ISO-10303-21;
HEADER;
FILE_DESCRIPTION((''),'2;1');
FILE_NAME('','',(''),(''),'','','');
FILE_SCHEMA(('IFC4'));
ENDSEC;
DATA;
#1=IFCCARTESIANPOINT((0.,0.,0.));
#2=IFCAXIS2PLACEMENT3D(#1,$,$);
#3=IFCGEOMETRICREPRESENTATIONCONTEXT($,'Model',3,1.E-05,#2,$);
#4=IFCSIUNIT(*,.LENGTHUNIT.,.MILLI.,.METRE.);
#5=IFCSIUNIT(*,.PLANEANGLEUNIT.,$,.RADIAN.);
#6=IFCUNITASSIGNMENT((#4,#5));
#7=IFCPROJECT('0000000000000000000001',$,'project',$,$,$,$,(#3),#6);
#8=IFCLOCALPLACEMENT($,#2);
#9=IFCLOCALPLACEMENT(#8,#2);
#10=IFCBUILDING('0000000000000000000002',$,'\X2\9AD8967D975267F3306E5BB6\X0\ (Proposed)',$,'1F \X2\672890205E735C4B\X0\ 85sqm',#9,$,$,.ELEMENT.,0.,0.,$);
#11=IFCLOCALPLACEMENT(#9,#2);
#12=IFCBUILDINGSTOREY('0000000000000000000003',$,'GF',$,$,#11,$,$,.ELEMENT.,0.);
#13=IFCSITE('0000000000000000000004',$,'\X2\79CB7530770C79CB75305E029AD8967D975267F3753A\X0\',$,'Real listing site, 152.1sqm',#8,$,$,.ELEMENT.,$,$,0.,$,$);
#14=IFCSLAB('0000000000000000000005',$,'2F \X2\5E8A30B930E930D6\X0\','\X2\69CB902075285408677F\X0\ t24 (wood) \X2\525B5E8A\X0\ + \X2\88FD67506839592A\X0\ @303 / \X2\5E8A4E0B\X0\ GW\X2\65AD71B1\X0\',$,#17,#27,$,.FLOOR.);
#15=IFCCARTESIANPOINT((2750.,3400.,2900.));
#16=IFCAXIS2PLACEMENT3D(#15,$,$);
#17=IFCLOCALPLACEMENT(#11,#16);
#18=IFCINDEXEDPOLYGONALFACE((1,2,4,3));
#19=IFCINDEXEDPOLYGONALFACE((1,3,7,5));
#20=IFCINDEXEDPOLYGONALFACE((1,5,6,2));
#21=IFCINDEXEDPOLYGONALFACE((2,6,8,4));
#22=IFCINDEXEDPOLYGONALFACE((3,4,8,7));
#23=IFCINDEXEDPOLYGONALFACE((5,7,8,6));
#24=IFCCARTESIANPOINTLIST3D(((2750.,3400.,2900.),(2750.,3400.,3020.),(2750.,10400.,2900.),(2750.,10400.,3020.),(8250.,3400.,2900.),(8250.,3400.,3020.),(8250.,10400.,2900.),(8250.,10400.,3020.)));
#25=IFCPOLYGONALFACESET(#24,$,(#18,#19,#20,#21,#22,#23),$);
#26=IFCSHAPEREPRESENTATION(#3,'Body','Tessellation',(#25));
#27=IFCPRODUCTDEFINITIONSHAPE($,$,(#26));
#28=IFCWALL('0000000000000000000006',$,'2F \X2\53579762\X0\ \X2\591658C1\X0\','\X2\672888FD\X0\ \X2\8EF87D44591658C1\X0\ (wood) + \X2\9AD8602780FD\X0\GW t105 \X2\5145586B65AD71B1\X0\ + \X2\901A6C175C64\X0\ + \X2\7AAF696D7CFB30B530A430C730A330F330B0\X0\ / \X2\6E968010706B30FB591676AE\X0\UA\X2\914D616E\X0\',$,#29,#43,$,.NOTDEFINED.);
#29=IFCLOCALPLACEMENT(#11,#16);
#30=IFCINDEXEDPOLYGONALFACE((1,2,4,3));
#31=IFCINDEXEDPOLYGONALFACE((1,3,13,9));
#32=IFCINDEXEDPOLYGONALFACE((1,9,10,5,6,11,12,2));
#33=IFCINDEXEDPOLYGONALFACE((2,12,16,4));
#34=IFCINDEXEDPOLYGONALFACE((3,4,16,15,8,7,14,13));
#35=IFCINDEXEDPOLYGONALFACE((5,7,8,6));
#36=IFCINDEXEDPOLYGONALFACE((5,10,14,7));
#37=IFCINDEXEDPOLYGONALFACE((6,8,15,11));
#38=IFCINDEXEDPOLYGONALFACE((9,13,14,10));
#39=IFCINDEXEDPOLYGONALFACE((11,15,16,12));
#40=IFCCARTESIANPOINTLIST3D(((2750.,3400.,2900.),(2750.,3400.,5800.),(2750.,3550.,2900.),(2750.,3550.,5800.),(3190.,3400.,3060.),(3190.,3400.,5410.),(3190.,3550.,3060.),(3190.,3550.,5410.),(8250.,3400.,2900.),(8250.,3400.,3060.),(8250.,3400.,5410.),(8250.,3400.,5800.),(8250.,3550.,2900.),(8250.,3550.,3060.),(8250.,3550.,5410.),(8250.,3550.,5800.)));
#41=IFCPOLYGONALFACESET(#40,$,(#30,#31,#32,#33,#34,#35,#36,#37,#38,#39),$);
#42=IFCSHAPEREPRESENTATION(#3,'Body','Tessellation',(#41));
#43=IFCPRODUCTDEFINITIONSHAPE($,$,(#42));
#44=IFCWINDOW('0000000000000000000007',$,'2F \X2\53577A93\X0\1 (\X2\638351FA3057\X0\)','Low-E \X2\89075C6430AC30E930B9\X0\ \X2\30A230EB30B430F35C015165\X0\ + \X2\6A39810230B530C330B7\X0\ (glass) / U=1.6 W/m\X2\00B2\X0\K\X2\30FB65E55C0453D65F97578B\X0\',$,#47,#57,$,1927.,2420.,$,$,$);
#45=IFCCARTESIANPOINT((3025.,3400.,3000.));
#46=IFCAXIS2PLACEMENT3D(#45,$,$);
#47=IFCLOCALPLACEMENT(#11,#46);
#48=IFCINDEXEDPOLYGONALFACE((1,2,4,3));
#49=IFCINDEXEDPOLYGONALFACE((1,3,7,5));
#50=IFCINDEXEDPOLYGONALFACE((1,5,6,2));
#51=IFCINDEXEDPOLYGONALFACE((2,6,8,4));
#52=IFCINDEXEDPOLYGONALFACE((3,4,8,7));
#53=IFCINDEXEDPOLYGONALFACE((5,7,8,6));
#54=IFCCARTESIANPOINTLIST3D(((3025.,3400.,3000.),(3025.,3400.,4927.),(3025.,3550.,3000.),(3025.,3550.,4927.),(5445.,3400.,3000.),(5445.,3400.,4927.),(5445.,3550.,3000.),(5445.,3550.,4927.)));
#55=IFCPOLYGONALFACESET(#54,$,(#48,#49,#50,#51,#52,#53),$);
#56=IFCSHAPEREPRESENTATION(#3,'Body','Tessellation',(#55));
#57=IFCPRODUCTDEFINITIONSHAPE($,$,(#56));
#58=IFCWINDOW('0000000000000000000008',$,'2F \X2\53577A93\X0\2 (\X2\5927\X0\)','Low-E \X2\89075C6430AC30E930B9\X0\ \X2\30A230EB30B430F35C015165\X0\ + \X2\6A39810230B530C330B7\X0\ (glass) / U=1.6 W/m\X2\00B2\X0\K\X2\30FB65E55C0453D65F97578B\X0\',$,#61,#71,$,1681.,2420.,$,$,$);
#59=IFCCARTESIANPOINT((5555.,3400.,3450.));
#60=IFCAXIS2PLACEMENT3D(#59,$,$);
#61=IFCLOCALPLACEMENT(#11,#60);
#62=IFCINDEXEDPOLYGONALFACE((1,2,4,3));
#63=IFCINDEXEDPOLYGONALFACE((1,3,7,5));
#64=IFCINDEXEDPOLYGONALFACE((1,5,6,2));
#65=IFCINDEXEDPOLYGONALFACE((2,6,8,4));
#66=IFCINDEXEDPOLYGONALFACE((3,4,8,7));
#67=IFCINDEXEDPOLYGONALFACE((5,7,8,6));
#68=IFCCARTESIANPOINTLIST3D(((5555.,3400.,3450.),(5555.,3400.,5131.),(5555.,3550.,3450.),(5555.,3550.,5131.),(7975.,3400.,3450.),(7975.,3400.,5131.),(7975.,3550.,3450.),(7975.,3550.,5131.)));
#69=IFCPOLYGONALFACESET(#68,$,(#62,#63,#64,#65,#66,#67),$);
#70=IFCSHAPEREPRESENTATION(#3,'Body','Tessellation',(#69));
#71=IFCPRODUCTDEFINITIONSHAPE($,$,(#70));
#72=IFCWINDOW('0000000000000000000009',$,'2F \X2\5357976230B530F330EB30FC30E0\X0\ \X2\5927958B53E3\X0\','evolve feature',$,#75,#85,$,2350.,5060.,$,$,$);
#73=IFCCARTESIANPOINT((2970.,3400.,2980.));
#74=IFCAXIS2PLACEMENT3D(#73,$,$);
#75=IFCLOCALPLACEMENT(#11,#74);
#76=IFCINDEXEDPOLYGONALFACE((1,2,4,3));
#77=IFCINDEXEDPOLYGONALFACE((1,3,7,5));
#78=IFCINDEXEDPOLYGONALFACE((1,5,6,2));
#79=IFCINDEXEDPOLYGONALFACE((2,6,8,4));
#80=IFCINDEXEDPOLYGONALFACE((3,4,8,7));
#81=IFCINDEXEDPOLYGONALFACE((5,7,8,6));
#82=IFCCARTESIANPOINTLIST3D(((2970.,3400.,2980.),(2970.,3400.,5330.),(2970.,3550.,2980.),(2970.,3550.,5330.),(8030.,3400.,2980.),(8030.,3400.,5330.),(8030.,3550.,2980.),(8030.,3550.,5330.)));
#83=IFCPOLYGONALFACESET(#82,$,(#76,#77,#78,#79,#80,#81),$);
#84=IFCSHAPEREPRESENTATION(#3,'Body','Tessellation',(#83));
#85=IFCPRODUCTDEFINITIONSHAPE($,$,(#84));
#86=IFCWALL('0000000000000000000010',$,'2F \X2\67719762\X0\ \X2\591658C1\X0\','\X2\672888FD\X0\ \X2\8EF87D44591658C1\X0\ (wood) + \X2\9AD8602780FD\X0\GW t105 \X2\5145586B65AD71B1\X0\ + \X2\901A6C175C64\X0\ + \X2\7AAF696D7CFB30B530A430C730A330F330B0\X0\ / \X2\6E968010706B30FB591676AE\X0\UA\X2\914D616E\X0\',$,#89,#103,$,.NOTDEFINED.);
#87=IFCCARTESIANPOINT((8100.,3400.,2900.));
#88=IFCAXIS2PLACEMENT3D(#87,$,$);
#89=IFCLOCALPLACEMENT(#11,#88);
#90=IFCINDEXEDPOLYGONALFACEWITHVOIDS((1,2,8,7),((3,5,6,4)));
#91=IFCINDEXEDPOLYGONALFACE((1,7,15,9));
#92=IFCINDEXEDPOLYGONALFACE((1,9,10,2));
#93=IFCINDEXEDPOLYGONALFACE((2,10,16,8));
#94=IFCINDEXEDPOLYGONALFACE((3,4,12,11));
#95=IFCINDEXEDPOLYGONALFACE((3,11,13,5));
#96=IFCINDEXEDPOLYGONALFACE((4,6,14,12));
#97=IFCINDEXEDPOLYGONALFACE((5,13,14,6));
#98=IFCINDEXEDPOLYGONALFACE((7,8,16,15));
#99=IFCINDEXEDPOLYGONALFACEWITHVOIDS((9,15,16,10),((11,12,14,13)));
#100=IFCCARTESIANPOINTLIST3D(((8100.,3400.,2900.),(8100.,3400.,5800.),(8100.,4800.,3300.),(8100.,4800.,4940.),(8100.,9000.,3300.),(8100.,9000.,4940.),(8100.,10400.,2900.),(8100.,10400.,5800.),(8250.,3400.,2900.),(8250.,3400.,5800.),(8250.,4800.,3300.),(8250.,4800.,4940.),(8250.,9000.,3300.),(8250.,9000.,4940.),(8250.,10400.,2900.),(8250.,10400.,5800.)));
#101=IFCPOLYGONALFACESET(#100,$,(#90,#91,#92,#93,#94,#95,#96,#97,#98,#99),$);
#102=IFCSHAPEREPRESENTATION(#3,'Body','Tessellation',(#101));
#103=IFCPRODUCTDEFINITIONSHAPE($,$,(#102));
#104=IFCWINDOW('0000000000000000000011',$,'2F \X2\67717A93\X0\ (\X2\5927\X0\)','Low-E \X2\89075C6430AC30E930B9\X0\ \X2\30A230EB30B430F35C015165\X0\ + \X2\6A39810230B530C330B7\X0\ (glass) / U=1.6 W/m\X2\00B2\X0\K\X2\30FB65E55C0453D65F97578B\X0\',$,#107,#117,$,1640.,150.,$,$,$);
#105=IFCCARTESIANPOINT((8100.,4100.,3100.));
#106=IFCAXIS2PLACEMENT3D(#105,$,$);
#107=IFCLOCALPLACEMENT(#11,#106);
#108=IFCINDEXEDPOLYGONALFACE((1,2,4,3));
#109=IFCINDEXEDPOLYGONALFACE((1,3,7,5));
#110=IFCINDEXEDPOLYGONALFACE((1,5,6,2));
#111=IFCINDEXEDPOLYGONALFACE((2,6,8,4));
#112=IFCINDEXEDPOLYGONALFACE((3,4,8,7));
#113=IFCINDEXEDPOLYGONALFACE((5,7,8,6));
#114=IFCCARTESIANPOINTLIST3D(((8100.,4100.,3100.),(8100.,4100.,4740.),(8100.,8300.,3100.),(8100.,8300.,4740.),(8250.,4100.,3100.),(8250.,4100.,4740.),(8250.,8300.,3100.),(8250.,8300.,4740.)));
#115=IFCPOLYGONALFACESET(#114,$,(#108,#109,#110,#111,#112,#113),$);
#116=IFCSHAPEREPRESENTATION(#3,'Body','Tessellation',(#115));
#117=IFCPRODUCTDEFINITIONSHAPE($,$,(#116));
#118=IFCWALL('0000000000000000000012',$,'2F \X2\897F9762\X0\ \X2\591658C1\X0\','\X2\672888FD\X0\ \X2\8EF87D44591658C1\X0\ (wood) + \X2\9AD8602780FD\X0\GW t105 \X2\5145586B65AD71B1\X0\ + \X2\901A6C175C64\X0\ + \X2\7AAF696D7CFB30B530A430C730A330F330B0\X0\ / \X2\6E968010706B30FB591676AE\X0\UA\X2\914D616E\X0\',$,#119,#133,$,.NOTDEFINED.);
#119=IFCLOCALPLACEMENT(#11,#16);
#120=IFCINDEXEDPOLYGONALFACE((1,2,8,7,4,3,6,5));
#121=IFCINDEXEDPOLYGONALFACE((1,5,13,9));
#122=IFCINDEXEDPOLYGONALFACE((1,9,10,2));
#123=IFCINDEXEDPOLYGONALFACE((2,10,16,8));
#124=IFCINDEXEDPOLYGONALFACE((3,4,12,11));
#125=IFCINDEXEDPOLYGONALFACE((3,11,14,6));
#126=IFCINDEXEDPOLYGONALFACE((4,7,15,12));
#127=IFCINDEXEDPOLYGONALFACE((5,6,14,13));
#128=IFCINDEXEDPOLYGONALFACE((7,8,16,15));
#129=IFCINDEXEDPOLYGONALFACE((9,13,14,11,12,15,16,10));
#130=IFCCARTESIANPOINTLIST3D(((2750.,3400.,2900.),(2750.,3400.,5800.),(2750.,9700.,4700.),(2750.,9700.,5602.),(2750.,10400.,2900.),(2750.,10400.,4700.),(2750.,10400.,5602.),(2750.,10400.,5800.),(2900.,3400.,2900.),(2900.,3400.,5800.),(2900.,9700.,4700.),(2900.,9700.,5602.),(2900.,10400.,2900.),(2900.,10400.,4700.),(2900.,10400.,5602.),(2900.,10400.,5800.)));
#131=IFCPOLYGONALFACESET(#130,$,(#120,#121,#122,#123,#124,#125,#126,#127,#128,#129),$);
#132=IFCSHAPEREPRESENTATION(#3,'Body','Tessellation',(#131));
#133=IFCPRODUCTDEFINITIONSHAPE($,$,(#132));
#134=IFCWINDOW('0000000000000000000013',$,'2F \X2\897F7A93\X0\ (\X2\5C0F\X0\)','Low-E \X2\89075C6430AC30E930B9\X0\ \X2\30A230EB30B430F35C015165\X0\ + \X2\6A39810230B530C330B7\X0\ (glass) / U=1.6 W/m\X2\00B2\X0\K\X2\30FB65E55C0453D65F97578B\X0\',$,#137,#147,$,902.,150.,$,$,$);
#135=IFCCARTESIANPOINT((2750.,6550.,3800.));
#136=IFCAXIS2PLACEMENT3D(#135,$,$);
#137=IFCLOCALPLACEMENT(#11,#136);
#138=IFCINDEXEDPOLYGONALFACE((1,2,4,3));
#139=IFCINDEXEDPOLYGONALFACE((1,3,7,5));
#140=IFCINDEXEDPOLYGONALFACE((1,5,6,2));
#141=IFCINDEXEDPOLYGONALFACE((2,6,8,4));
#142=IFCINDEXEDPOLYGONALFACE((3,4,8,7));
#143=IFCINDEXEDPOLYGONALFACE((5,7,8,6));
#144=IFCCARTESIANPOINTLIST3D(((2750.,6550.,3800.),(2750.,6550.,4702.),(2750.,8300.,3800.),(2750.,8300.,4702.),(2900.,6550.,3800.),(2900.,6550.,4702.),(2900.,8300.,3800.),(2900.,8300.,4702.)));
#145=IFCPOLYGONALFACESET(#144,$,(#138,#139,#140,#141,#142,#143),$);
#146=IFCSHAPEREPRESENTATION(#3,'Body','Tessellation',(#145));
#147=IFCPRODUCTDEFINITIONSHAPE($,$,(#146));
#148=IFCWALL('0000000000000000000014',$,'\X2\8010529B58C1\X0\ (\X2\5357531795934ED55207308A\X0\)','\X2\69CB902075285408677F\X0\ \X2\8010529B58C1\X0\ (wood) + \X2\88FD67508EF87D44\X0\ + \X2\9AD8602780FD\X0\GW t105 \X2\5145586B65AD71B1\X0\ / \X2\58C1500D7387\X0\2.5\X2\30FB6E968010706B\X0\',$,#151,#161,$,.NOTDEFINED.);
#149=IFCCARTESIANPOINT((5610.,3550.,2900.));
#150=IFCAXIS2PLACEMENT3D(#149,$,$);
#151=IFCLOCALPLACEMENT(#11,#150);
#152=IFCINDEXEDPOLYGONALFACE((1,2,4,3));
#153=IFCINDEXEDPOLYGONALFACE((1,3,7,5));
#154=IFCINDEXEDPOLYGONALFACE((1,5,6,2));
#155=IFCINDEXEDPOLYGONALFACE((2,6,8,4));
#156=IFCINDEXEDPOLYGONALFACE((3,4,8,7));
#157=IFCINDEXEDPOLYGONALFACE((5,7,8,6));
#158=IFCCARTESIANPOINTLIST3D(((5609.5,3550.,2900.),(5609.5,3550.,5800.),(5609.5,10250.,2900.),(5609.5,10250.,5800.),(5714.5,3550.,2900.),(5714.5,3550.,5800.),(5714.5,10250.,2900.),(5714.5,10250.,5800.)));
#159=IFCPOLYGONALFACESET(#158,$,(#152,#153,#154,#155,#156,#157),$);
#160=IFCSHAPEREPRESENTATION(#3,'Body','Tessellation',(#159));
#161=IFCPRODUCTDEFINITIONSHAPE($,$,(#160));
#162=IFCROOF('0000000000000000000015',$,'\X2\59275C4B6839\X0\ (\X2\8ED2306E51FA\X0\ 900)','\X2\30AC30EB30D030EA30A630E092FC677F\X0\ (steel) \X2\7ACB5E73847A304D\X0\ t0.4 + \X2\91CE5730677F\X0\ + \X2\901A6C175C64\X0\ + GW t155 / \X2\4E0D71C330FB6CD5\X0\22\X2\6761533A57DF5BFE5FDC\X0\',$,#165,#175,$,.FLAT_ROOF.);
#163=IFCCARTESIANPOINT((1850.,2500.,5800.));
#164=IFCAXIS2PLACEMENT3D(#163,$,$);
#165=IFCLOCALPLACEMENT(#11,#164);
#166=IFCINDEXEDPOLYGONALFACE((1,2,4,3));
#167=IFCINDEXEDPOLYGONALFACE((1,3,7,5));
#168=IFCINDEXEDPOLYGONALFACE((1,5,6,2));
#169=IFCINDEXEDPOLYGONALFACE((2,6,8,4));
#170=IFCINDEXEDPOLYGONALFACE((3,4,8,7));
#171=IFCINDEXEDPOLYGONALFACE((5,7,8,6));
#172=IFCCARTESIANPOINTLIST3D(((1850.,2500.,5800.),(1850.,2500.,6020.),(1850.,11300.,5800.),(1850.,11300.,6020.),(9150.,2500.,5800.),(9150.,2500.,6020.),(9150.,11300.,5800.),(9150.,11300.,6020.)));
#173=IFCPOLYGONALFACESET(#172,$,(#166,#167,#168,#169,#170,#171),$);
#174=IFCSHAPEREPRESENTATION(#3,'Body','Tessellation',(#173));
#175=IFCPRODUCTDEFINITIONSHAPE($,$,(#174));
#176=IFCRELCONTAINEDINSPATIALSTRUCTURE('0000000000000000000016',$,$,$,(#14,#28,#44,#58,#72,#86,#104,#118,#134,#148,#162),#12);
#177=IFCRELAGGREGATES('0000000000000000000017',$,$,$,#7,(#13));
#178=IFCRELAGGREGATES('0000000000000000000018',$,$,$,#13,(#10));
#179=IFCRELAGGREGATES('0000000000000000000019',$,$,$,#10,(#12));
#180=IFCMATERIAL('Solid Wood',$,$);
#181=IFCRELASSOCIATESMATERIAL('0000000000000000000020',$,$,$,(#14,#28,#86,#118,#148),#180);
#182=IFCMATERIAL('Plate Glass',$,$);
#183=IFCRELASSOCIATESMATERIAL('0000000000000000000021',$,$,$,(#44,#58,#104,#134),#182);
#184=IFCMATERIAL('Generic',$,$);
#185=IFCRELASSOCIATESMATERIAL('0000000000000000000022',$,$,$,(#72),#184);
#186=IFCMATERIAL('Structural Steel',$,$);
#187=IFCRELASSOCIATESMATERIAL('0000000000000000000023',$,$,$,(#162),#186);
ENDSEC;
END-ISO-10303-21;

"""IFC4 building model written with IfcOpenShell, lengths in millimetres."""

from ifc_helpers import new_model, si_unit, frame, frame_2d, origin, place, context, project, spatial, rectangle, extrude, material, element, fill, save


model = new_model("IFC4")

# Units and contexts
model_context = context("Model", 3, precision=1e-05, world=origin())
ifc_project = project(units=[si_unit("LENGTHUNIT", "METRE", prefix="MILLI"), si_unit("PLANEANGLEUNIT", "RADIAN")], contexts=[model_context])

# Site, building, storey
site_placement = place(None, origin())
site = spatial("IfcSite", under=ifc_project, at=site_placement, Name="秋田県秋田市高陽青柳町", ObjectType="Real listing site, 152.1sqm", CompositionType="ELEMENT", RefElevation=0.0)
building_placement = place(site_placement, origin())
building = spatial("IfcBuilding", under=site, at=building_placement, Name="高陽青柳の家 (Proposed)", ObjectType="1F 木造平屋 85sqm", CompositionType="ELEMENT", ElevationOfRefHeight=0.0, ElevationOfTerrain=0.0)
storey_placement = place(building_placement, origin())
storey = spatial("IfcBuildingStorey", under=building, at=storey_placement, Name="GF", CompositionType="ELEMENT", Elevation=0.0)

# Slab
ifc_material_1 = material(Name="Solid Wood")
slab_placement = place(storey_placement, frame((2750.0, 3400.0, 2900.0)))
element("IfcSlab", 1, at=slab_placement, inside=storey, material=ifc_material_1, Name="2F 床スラブ", Description="構造用合板 t24 (wood) 剛床 + 製材根太 @303 / 床下 GW断熱", PredefinedType="FLOOR", context=model_context, shape_type="SweptSolid", body=[
    extrude(rectangle(XDim=5500.0, YDim=7000.0, at=frame_2d((2750.0, 3500.0))), frame((2750.0, 3400.0, 2900.0)), (0.0, 0.0, 1.0), 120.0),
])

# Wall, openings, windows
wall_1_placement = place(storey_placement, frame((2750.0, 3400.0, 2900.0)))
wall_1 = element("IfcWall", 2, at=wall_1_placement, inside=storey, material=ifc_material_1, Name="2F 南面 外壁", Description="木製 軸組外壁 (wood) + 高性能GW t105 充填断熱 + 通気層 + 窯業系サイディング / 準耐火・外皮UA配慮", PredefinedType="NOTDEFINED", context=model_context, shape_type="SweptSolid", body=[
    extrude(rectangle(XDim=5500.0, YDim=150.0, at=frame_2d((2750.0, 75.0))), frame((2750.0, 3400.0, 2900.0)), (0.0, 0.0, 1.0), 2900.0),
])
opening_1_placement = place(storey_placement, frame((3025.0, 3400.0, 3000.0)))
opening_1 = element("IfcOpeningElement", 3, at=opening_1_placement, cuts=wall_1, PredefinedType="NOTDEFINED", context=model_context, shape_type="SweptSolid", body=[
    extrude(rectangle(XDim=2420.0, YDim=150.0, at=frame_2d((1210.0, 75.0))), frame((3025.0, 3400.0, 3000.0)), (0.0, 0.0, 1.0), 1927.0),
])
opening_2_placement = place(storey_placement, frame((5555.0, 3400.0, 3450.0)))
opening_2 = element("IfcOpeningElement", 4, at=opening_2_placement, cuts=wall_1, PredefinedType="NOTDEFINED", context=model_context, shape_type="SweptSolid", body=[
    extrude(rectangle(XDim=2420.0, YDim=150.0, at=frame_2d((1210.0, 75.0))), frame((5555.0, 3400.0, 3450.0)), (0.0, 0.0, 1.0), 1681.0),
])
opening_3_placement = place(storey_placement, frame((2970.0, 3400.0, 2980.0)))
opening_3 = element("IfcOpeningElement", 5, at=opening_3_placement, cuts=wall_1, PredefinedType="NOTDEFINED", context=model_context, shape_type="SweptSolid", body=[
    extrude(rectangle(XDim=5060.0, YDim=150.0, at=frame_2d((2530.0, 75.0))), frame((2970.0, 3400.0, 2980.0)), (0.0, 0.0, 1.0), 2350.0),
])
ifc_material_2 = material(Name="Plate Glass")
window_1_placement = place(storey_placement, frame((3025.0, 3400.0, 3000.0)))
window_1 = element("IfcWindow", 6, at=window_1_placement, inside=storey, material=ifc_material_2, Name="2F 南窓1 (掃出し)", Description="Low-E 複層ガラス アルゴン封入 + 樹脂サッシ (glass) / U=1.6 W/m²K・日射取得型", OverallHeight=1927.0, OverallWidth=2420.0, context=model_context, shape_type="SweptSolid", body=[
    extrude(rectangle(XDim=2420.0, YDim=150.0, at=frame_2d((1210.0, 75.0))), frame((3025.0, 3400.0, 3000.0)), (0.0, 0.0, 1.0), 1927.0),
])
fill(opening_1, window_1)
window_2_placement = place(storey_placement, frame((5555.0, 3400.0, 3450.0)))
window_2 = element("IfcWindow", 7, at=window_2_placement, inside=storey, material=ifc_material_2, Name="2F 南窓2 (大)", Description="Low-E 複層ガラス アルゴン封入 + 樹脂サッシ (glass) / U=1.6 W/m²K・日射取得型", OverallHeight=1681.0, OverallWidth=2420.0, context=model_context, shape_type="SweptSolid", body=[
    extrude(rectangle(XDim=2420.0, YDim=150.0, at=frame_2d((1210.0, 75.0))), frame((5555.0, 3400.0, 3450.0)), (0.0, 0.0, 1.0), 1681.0),
])
fill(opening_2, window_2)
ifc_material_3 = material(Name="Generic")
window_3_placement = place(storey_placement, frame((2970.0, 3400.0, 2980.0)))
window_3 = element("IfcWindow", 8, at=window_3_placement, inside=storey, material=ifc_material_3, Name="2F 南面サンルーム 大開口", Description="evolve feature", OverallHeight=2350.0, OverallWidth=5060.0, context=model_context, shape_type="SweptSolid", body=[
    extrude(rectangle(XDim=5060.0, YDim=150.0, at=frame_2d((2530.0, 75.0))), frame((2970.0, 3400.0, 2980.0)), (0.0, 0.0, 1.0), 2350.0),
])
fill(opening_3, window_3)

# Walls, openings, windows
wall_2_placement = place(storey_placement, frame((8100.0, 3400.0, 2900.0)))
wall_2 = element("IfcWall", 9, at=wall_2_placement, inside=storey, material=ifc_material_1, Name="2F 東面 外壁", Description="木製 軸組外壁 (wood) + 高性能GW t105 充填断熱 + 通気層 + 窯業系サイディング / 準耐火・外皮UA配慮", PredefinedType="NOTDEFINED", context=model_context, shape_type="SweptSolid", body=[
    extrude(rectangle(XDim=150.0, YDim=7000.0, at=frame_2d((75.0, 3500.0))), frame((8100.0, 3400.0, 2900.0)), (0.0, 0.0, 1.0), 2900.0),
])
opening_4_placement = place(storey_placement, frame((8100.0, 4100.0, 3100.0)))
opening_4 = element("IfcOpeningElement", 10, at=opening_4_placement, cuts=wall_2, PredefinedType="NOTDEFINED", context=model_context, shape_type="SweptSolid", body=[
    extrude(rectangle(XDim=150.0, YDim=4200.0, at=frame_2d((75.0, 2100.0))), frame((8100.0, 4100.0, 3100.0)), (0.0, 0.0, 1.0), 1640.0),
])
window_4_placement = place(storey_placement, frame((8100.0, 4100.0, 3100.0)))
window_4 = element("IfcWindow", 11, at=window_4_placement, inside=storey, material=ifc_material_2, Name="2F 東窓 (大)", Description="Low-E 複層ガラス アルゴン封入 + 樹脂サッシ (glass) / U=1.6 W/m²K・日射取得型", OverallHeight=1640.0, OverallWidth=150.0, context=model_context, shape_type="SweptSolid", body=[
    extrude(rectangle(XDim=150.0, YDim=4200.0, at=frame_2d((75.0, 2100.0))), frame((8100.0, 4100.0, 3100.0)), (0.0, 0.0, 1.0), 1640.0),
])
fill(opening_4, window_4)
wall_3_placement = place(storey_placement, frame((2750.0, 3400.0, 2900.0)))
wall_3 = element("IfcWall", 12, at=wall_3_placement, inside=storey, material=ifc_material_1, Name="2F 西面 外壁", Description="木製 軸組外壁 (wood) + 高性能GW t105 充填断熱 + 通気層 + 窯業系サイディング / 準耐火・外皮UA配慮", PredefinedType="NOTDEFINED", context=model_context, shape_type="SweptSolid", body=[
    extrude(rectangle(XDim=150.0, YDim=7000.0, at=frame_2d((75.0, 3500.0))), frame((2750.0, 3400.0, 2900.0)), (0.0, 0.0, 1.0), 2900.0),
])
opening_5_placement = place(storey_placement, frame((2750.0, 6550.0, 3800.0)))
opening_5 = element("IfcOpeningElement", 13, at=opening_5_placement, cuts=wall_3, PredefinedType="NOTDEFINED", context=model_context, shape_type="SweptSolid", body=[
    extrude(rectangle(XDim=150.0, YDim=1750.0, at=frame_2d((75.0, 875.0))), frame((2750.0, 6550.0, 3800.0)), (0.0, 0.0, 1.0), 902.0),
])
window_5_placement = place(storey_placement, frame((2750.0, 6550.0, 3800.0)))
window_5 = element("IfcWindow", 14, at=window_5_placement, inside=storey, material=ifc_material_2, Name="2F 西窓 (小)", Description="Low-E 複層ガラス アルゴン封入 + 樹脂サッシ (glass) / U=1.6 W/m²K・日射取得型", OverallHeight=902.0, OverallWidth=150.0, context=model_context, shape_type="SweptSolid", body=[
    extrude(rectangle(XDim=150.0, YDim=1750.0, at=frame_2d((75.0, 875.0))), frame((2750.0, 6550.0, 3800.0)), (0.0, 0.0, 1.0), 902.0),
])
fill(opening_5, window_5)

# Wall
wall_4_placement = place(storey_placement, frame((5610.0, 3550.0, 2900.0)))
element("IfcWall", 15, at=wall_4_placement, inside=storey, material=ifc_material_1, Name="耐力壁 (南北間仕切り)", Description="構造用合板 耐力壁 (wood) + 製材軸組 + 高性能GW t105 充填断熱 / 壁倍率2.5・準耐火", PredefinedType="NOTDEFINED", context=model_context, shape_type="SweptSolid", body=[
    extrude(rectangle(XDim=105.0, YDim=6700.0, at=frame_2d((52.0, 3350.0))), frame((5610.0, 3550.0, 2900.0)), (0.0, 0.0, 1.0), 2900.0),
])

# Roof
ifc_material_4 = material(Name="Structural Steel")
roof_placement = place(storey_placement, frame((1850.0, 2500.0, 5800.0)))
element("IfcRoof", 16, at=roof_placement, inside=storey, material=ifc_material_4, Name="大屋根 (軒の出 900)", Description="ガルバリウム鋼板 (steel) 立平葺き t0.4 + 野地板 + 通気層 + GW t155 / 不燃・法22条区域対応", PredefinedType="FLAT_ROOF", context=model_context, shape_type="SweptSolid", body=[
    extrude(rectangle(XDim=7300.0, YDim=8800.0, at=frame_2d((3650.0, 4400.0))), frame((1850.0, 2500.0, 5800.0)), (0.0, 0.0, 1.0), 220.0),
])

save(model, "model.ifc")
